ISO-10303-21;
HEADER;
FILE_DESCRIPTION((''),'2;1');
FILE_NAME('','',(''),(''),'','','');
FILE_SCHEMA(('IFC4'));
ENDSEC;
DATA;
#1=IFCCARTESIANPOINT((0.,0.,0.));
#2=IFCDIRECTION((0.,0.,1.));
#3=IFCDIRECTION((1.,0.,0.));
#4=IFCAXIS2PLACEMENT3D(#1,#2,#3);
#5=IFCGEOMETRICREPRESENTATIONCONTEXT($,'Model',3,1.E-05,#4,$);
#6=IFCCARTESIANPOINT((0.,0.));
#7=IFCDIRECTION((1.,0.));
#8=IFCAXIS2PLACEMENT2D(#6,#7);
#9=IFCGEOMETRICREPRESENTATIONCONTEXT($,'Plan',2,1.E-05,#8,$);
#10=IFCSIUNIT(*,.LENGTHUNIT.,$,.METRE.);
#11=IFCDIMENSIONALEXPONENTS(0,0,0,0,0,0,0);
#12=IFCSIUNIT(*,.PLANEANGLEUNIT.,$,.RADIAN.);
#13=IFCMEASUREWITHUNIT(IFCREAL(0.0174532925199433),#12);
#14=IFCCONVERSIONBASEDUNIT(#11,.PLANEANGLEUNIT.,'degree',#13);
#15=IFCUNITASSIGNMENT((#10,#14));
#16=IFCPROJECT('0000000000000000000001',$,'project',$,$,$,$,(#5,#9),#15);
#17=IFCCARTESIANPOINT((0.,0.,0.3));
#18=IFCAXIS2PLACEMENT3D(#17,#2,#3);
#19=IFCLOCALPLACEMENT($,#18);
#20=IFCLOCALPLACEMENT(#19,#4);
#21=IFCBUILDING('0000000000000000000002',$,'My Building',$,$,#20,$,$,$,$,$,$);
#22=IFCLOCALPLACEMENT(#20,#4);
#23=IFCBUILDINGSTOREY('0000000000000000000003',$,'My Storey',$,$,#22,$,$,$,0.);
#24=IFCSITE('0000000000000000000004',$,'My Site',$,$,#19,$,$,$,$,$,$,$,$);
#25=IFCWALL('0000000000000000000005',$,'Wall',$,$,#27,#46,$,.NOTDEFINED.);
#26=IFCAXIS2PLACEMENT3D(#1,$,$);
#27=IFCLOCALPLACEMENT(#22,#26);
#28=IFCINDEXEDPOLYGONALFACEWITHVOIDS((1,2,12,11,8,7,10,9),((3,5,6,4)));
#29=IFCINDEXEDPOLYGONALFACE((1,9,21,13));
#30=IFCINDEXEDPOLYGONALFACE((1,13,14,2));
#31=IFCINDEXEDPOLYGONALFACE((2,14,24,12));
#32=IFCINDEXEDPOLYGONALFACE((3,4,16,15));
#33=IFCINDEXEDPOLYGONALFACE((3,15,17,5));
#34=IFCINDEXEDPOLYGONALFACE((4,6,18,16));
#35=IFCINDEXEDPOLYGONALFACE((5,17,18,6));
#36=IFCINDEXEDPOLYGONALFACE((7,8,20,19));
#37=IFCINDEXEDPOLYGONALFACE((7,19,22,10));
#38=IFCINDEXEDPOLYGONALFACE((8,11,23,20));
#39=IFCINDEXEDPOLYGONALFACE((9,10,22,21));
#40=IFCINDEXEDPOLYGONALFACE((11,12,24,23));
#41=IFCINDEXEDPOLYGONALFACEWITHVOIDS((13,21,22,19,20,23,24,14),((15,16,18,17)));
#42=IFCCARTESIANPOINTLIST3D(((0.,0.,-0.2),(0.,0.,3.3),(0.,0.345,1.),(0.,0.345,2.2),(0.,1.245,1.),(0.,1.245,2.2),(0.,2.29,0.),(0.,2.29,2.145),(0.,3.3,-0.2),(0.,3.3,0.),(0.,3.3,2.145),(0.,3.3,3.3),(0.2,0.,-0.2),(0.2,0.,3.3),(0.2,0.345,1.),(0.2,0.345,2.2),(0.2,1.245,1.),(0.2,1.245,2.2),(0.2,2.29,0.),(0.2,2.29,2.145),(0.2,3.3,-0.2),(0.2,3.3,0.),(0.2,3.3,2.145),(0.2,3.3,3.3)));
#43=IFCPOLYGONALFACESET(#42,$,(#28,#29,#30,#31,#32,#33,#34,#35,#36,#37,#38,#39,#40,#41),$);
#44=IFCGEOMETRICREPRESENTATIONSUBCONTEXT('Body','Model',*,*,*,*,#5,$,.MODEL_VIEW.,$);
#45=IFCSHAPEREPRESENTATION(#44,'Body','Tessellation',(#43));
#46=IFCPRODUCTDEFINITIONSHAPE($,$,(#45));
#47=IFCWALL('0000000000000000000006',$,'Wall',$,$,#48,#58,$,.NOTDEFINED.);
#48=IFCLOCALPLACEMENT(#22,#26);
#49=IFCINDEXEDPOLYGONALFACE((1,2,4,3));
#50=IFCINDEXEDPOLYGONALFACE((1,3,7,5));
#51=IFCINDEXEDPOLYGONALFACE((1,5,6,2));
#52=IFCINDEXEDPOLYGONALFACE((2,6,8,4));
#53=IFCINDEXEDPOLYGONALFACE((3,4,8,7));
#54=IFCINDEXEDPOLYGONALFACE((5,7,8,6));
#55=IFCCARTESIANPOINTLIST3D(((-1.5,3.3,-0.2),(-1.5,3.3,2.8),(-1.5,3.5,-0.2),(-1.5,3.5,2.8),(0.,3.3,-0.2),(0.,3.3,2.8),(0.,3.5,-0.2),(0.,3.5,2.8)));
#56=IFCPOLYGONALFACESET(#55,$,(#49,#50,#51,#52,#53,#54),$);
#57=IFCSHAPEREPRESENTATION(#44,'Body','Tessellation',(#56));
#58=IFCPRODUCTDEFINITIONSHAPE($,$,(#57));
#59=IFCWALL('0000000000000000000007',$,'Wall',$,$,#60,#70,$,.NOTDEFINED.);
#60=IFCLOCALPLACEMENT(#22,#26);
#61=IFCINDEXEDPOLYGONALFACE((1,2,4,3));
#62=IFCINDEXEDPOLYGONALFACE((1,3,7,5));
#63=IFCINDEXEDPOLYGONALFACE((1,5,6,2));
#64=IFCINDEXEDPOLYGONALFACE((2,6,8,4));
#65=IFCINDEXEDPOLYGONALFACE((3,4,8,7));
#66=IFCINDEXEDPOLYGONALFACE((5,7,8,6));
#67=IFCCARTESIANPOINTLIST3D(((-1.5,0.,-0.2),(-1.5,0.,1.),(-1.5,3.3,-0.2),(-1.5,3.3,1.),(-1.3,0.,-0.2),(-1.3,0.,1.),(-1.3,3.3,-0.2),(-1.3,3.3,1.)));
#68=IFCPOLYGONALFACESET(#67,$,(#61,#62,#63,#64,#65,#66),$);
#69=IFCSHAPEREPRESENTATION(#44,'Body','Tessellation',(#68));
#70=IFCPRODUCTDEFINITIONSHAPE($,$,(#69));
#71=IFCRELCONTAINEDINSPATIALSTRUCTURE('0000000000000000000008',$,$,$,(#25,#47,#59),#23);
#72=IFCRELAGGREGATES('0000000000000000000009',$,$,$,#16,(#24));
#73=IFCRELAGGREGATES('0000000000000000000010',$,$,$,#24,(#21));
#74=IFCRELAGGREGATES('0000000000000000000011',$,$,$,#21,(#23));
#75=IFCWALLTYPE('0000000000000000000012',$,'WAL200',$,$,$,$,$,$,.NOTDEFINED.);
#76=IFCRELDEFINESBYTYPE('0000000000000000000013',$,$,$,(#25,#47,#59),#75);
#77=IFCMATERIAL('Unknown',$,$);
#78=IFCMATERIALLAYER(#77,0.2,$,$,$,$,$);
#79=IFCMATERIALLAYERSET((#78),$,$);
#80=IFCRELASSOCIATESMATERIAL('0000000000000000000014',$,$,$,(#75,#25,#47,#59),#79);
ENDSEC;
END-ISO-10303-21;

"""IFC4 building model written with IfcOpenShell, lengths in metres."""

from ifc_helpers import new_model, entity, si_unit, converted_unit, frame, origin_with_axes, origin_2d_with_axis, place, context, subcontext, project, spatial, line, indexed_curve, outline, extrude, source, transform, mapped, material, layer, layer_set, layer_usage, type_object, element, save


model = new_model("IFC4")

# Units and contexts
model_context = context("Model", 3, precision=1e-05, world=origin_with_axes())
plan_context = context("Plan", 2, precision=1e-05, world=origin_2d_with_axis())
body_context = subcontext(model_context, "Body", "Model", "MODEL_VIEW")
ifc_project = project(units=[si_unit("LENGTHUNIT", "METRE"), converted_unit("PLANEANGLEUNIT", "degree", entity("IfcReal", 0.0174532925199433), si_unit("PLANEANGLEUNIT", "RADIAN"), dimensions=[0, 0, 0, 0, 0, 0, 0])], contexts=[model_context, plan_context])

# Site, building, storey
site_placement = place(None, frame((0.0, 0.0, 0.3), z_axis=(0.0, 0.0, 1.0), x_axis=(1.0, 0.0, 0.0)))
site = spatial("IfcSite", under=ifc_project, at=site_placement, Name="My Site")
building_placement = place(site_placement, origin_with_axes())
building = spatial("IfcBuilding", under=site, at=building_placement, Name="My Building")
storey_placement = place(building_placement, origin_with_axes())
storey = spatial("IfcBuildingStorey", under=building, at=storey_placement, Name="My Storey", Elevation=0.0)

# Shared definitions
ifc_material = material(Name="Unknown")

# Shared definitions
shared_shape_1 = source(origin_with_axes(), body_context, "Body", "SweptSolid", [
    extrude(outline(indexed_curve([(0.0, 0.0), (1.01, 0.0), (1.01, 2.145), (0.0, 2.145)], segments=[line(1, 2), line(2, 3), line(3, 4), line(4, 1)])), frame((0.0, -0.1, 0.0), z_axis=(0.0, -1.0, 0.0), x_axis=(1.0, 0.0, 0.0)), (0.0, 0.0, -1.0), 0.4),
])

# Shared definitions
ifc_layer_1 = layer(ifc_material, 0.2)
ifc_layer_set_1 = layer_set([ifc_layer_1])
wall_type_1 = type_object("IfcWallType", Name="WAL200", PredefinedType="NOTDEFINED", material=ifc_layer_set_1)

# Shared definitions
shared_shape_2 = source(origin_with_axes(), body_context, "Body", "SweptSolid", [
    extrude(outline(indexed_curve([(0.0, 0.0), (0.9, 0.0), (0.9, 1.2), (0.0, 1.2)], segments=[line(1, 2), line(2, 3), line(3, 4), line(4, 1)])), frame((0.0, -0.1, 0.0), z_axis=(0.0, -1.0, 0.0), x_axis=(1.0, 0.0, 0.0)), (0.0, 0.0, -1.0), 0.4),
])

# Wall, openings
ifc_layer_usage_1 = layer_usage(ifc_layer_set_1, "AXIS2", "POSITIVE", 0.0)
wall_1_placement = place(storey_placement, frame((0.0, 3.3, -0.2), z_axis=(0.0, 0.0, 1.0), x_axis=(0.0, -1.0, 0.0)))
wall_1 = element("IfcWall", 1, at=wall_1_placement, inside=storey, type_object=wall_type_1, material=ifc_layer_usage_1, Name="Wall", PredefinedType="NOTDEFINED", context=body_context, shape_type="SweptSolid", body=[
    extrude(outline(indexed_curve([(0.0, 0.0), (0.0, 0.2), (3.3, 0.2), (3.3, 0.0), (0.0, 0.0)], self_intersect=False)), origin_with_axes(), (0.0, 0.0, 1.0), 3.5),
])
opening_1_placement = place(wall_1_placement, frame((0.0, 0.0, 0.2), z_axis=(0.0, 0.0, 1.0), x_axis=(1.0, 0.0, 0.0)))
element("IfcOpeningElement", 2, at=opening_1_placement, cuts=wall_1, PredefinedType="OPENING", context=body_context, shape_type="MappedRepresentation", body=[
    mapped(shared_shape_1, transform((0.0, 0.0, 0.0), x_axis=(1.0, 0.0, 0.0), y_axis=(0.0, 1.0, 0.0), z_axis=(0.0, 0.0, 1.0), scale=1.0)),
])
opening_2_placement = place(wall_1_placement, frame((2.055, 0.0, 1.2), z_axis=(0.0, 0.0, 1.0), x_axis=(1.0, 0.0, 0.0)))
element("IfcOpeningElement", 3, at=opening_2_placement, cuts=wall_1, PredefinedType="OPENING", context=body_context, shape_type="MappedRepresentation", body=[
    mapped(shared_shape_2, transform((0.0, 0.0, 0.0), x_axis=(1.0, 0.0, 0.0), y_axis=(0.0, 1.0, 0.0), z_axis=(0.0, 0.0, 1.0), scale=1.0)),
])

# Walls
ifc_layer_usage_2 = layer_usage(ifc_layer_set_1, "AXIS2", "POSITIVE", 0.0)
wall_2_placement = place(storey_placement, frame((0.0, 3.5, -0.2), z_axis=(0.0, 0.0, 1.0), x_axis=(-1.0, 0.0, 0.0)))
element("IfcWall", 4, at=wall_2_placement, inside=storey, type_object=wall_type_1, material=ifc_layer_usage_2, Name="Wall", PredefinedType="NOTDEFINED", context=body_context, shape_type="SweptSolid", body=[
    extrude(outline(indexed_curve([(0.0, 0.0), (0.0, 0.2), (1.5, 0.2), (1.5, 0.0), (0.0, 0.0)], self_intersect=False)), origin_with_axes(), (0.0, 0.0, 1.0), 3.0),
])
ifc_layer_usage_3 = layer_usage(ifc_layer_set_1, "AXIS2", "POSITIVE", 0.0)
wall_3_placement = place(storey_placement, frame((-1.5, 3.3, -0.2), z_axis=(0.0, 0.0, 1.0), x_axis=(0.0, -1.0, 0.0)))
element("IfcWall", 5, at=wall_3_placement, inside=storey, type_object=wall_type_1, material=ifc_layer_usage_3, Name="Wall", PredefinedType="NOTDEFINED", context=body_context, shape_type="SweptSolid", body=[
    extrude(outline(indexed_curve([(0.0, 0.0), (0.0, 0.2), (3.3, 0.2), (3.3, 0.0), (0.0, 0.0)], self_intersect=False)), origin_with_axes(), (0.0, 0.0, 1.0), 1.2),
])

save(model, "model.ifc")
